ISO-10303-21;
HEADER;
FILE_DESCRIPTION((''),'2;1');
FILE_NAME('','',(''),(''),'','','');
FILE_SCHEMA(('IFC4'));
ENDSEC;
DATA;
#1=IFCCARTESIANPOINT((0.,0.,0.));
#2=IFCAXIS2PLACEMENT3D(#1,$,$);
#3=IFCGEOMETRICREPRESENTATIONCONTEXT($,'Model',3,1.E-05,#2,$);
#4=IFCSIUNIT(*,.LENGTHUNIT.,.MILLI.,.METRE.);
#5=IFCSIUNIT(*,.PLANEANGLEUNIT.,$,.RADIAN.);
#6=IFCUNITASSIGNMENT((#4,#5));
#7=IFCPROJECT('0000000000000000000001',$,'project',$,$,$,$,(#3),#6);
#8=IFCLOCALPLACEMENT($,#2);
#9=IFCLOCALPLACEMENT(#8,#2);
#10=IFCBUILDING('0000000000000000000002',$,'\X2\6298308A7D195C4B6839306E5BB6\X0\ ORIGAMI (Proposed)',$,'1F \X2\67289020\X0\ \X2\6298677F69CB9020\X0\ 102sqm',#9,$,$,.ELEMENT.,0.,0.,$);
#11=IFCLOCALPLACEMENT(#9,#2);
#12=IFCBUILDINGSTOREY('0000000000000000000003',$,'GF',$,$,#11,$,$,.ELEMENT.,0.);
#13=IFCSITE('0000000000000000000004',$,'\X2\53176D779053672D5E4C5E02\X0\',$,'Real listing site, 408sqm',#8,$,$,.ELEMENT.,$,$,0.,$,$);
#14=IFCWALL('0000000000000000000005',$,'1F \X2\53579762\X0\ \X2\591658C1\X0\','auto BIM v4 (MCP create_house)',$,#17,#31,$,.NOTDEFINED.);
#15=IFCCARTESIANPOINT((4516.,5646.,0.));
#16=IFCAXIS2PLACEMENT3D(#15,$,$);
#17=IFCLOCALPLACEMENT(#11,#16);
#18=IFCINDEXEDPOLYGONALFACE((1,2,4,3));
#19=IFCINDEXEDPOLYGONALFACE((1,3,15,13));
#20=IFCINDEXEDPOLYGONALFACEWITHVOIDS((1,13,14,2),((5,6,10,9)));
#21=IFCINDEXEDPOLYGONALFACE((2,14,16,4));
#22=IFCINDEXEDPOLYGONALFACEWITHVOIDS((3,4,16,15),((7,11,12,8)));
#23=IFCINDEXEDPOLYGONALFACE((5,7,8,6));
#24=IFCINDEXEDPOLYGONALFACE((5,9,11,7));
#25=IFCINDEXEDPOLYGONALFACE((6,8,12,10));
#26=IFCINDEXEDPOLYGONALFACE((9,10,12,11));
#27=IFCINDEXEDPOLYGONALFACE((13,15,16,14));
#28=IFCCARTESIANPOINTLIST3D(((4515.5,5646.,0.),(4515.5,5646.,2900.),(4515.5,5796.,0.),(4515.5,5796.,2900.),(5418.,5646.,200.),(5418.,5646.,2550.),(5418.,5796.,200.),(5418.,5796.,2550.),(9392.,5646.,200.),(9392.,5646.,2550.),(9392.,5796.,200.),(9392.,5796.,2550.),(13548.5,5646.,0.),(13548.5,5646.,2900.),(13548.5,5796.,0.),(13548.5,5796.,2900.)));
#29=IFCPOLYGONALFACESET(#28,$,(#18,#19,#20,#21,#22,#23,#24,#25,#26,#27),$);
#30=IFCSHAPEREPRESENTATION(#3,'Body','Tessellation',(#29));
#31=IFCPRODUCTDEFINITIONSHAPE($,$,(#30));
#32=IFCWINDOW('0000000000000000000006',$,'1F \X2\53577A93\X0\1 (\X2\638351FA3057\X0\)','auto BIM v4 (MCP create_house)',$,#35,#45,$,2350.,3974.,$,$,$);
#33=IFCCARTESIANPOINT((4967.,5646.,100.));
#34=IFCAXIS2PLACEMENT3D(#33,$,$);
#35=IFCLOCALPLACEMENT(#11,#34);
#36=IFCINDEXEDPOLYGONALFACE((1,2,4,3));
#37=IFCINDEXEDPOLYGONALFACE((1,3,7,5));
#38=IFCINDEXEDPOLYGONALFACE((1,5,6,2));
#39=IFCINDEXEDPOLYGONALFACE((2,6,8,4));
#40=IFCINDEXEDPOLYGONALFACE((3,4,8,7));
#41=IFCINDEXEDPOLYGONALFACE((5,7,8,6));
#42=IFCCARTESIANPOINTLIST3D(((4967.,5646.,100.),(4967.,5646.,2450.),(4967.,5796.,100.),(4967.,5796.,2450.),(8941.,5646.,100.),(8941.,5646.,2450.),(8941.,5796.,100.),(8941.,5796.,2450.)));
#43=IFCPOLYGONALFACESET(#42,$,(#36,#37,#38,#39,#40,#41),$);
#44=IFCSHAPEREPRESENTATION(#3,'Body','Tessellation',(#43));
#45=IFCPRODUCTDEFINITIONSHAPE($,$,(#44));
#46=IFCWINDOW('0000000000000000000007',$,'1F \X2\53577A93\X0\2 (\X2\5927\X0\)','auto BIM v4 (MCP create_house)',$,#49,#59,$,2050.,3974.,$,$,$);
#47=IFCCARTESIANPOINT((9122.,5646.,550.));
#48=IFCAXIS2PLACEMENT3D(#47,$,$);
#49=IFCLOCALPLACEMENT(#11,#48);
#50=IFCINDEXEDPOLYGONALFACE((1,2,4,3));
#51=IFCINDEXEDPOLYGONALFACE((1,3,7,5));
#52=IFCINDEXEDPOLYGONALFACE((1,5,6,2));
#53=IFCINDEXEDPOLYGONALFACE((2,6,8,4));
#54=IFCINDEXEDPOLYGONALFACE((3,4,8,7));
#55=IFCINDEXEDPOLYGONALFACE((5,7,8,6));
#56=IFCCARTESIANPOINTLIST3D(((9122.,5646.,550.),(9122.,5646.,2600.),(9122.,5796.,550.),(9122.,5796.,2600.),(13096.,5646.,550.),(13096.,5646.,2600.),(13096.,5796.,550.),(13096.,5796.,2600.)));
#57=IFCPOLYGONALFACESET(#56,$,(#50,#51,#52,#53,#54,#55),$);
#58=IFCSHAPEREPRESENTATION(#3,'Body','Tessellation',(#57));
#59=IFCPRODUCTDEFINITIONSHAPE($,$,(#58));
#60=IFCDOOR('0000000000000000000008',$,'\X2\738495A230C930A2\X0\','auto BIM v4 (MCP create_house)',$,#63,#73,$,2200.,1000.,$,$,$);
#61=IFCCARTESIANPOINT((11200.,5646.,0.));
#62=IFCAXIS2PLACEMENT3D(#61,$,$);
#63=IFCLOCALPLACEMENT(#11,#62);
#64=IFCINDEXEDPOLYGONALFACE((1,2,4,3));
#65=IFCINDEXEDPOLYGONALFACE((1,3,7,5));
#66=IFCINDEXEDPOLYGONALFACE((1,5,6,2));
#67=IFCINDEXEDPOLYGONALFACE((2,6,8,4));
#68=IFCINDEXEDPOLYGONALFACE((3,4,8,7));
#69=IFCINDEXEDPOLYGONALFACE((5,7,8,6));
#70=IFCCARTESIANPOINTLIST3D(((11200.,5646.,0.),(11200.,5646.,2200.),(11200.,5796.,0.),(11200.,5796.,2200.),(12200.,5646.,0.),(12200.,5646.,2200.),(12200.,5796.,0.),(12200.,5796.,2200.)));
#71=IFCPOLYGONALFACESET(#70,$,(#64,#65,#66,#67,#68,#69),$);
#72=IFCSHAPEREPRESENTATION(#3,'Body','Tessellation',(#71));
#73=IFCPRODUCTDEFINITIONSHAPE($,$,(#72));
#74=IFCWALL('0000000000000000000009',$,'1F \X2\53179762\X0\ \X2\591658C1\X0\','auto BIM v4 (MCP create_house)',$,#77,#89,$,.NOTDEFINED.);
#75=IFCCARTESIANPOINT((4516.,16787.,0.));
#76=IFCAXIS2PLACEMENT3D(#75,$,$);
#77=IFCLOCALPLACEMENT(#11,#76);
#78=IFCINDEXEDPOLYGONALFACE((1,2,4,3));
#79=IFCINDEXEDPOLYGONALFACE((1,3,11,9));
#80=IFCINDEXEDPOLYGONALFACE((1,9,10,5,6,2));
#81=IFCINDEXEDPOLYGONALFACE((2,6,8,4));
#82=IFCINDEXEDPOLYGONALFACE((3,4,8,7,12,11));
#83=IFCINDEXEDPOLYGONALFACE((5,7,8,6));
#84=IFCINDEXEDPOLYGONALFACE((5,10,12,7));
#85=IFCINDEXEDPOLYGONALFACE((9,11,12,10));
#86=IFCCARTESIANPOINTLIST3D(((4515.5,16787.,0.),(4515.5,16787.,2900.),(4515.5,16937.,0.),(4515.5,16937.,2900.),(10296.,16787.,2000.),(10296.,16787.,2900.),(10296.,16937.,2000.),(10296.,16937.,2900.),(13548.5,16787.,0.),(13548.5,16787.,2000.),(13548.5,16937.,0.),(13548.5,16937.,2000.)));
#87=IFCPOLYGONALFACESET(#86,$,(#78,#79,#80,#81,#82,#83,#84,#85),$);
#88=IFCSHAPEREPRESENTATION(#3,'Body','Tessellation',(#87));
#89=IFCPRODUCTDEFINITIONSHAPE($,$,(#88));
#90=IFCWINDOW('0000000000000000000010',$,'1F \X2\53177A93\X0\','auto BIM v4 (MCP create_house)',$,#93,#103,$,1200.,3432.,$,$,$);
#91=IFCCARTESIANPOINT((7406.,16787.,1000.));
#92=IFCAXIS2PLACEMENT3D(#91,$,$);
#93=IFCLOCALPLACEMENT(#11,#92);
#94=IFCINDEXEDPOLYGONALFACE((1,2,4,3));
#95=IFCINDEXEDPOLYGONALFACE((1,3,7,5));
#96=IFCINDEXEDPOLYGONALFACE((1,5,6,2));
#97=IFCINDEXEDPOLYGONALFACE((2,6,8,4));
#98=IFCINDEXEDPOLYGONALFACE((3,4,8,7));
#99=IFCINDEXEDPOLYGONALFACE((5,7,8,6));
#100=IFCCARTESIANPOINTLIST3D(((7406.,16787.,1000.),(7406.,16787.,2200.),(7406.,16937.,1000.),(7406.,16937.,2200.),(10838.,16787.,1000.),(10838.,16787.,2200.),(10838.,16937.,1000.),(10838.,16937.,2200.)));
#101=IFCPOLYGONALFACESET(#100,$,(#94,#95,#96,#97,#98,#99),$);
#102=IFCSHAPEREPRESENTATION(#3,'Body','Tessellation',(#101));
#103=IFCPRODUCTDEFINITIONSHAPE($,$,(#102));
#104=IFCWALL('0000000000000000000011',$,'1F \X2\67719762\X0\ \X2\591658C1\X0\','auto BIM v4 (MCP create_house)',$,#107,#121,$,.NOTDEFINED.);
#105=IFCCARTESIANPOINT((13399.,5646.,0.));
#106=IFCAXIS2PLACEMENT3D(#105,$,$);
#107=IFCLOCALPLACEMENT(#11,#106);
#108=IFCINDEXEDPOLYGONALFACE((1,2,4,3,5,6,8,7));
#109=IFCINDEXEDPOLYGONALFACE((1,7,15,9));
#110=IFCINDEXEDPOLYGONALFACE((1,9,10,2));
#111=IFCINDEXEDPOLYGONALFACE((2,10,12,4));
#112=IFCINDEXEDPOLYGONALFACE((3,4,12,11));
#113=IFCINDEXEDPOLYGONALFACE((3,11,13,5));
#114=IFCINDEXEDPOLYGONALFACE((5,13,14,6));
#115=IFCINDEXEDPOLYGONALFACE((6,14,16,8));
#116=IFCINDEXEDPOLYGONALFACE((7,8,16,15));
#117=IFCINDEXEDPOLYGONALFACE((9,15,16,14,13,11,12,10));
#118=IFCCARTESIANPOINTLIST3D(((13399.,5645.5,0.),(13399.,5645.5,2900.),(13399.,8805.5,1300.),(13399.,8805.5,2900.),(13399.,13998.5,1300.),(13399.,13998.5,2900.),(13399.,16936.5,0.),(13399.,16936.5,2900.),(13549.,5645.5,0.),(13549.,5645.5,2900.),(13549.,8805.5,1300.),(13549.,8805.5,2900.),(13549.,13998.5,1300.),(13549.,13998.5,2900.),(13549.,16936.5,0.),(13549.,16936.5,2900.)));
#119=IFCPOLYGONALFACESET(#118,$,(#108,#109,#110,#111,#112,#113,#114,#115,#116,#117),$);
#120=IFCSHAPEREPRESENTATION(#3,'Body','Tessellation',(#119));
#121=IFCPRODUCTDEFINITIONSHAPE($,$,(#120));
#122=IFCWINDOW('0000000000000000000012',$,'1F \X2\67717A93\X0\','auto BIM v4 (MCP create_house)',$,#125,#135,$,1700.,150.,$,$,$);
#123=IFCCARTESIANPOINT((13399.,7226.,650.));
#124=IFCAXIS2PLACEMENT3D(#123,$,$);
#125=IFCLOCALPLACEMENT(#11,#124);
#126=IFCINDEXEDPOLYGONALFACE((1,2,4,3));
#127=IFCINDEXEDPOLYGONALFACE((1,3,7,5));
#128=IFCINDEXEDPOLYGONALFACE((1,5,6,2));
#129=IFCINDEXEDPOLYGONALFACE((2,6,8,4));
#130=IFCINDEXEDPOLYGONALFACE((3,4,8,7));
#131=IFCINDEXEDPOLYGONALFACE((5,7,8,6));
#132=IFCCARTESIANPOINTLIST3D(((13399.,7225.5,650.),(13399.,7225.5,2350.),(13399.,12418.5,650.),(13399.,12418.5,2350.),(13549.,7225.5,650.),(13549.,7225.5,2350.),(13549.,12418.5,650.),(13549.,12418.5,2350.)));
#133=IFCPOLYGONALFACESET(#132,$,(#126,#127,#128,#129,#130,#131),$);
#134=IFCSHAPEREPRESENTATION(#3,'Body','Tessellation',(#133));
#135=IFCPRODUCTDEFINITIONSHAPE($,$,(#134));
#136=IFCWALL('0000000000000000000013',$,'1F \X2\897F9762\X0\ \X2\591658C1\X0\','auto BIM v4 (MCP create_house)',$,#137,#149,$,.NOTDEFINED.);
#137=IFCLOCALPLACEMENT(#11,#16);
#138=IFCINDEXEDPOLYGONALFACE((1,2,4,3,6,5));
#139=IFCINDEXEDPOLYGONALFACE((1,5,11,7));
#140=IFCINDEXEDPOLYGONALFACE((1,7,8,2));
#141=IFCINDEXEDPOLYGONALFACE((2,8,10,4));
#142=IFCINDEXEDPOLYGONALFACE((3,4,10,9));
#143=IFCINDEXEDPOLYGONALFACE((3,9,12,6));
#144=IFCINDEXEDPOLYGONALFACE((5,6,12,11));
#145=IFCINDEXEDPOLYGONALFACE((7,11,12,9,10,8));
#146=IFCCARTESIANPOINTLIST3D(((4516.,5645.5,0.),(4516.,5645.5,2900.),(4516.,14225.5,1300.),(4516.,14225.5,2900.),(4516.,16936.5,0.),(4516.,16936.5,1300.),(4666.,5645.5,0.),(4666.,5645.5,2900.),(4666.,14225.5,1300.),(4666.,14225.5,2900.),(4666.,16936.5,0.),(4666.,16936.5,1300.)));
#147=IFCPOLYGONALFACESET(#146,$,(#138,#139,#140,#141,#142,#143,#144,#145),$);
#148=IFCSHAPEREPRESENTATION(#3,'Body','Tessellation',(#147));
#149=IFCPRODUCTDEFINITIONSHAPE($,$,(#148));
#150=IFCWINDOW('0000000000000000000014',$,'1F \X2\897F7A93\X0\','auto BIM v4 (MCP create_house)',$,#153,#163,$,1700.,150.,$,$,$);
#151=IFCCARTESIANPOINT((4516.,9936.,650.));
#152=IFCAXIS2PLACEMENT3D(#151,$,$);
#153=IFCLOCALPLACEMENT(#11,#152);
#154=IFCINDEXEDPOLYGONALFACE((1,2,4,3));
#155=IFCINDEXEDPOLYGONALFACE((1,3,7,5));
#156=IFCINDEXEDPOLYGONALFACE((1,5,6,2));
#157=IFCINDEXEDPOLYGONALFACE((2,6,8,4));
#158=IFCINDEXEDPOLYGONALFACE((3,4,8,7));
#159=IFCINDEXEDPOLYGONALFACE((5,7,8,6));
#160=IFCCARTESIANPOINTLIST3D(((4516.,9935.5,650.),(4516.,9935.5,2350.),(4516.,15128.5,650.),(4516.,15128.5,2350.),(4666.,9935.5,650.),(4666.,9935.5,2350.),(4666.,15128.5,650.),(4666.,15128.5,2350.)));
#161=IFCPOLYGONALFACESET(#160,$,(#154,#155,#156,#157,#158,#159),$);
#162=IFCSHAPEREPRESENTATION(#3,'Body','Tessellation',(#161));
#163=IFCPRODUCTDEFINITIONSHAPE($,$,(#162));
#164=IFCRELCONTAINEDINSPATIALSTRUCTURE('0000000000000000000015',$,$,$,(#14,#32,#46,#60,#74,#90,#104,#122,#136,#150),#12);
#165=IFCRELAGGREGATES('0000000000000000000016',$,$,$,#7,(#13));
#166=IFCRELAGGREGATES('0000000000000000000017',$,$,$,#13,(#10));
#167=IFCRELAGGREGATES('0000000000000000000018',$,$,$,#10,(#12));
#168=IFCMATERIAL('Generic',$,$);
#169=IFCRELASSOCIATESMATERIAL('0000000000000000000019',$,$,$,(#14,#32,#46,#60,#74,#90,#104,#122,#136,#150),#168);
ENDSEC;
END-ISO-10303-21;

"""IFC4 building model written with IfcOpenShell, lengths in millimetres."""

from ifc_helpers import new_model, si_unit, frame, frame_2d, origin, place, context, project, spatial, rectangle, extrude, material, element, fill, save


model = new_model("IFC4")

# Units and contexts
model_context = context("Model", 3, precision=1e-05, world=origin())
ifc_project = project(units=[si_unit("LENGTHUNIT", "METRE", prefix="MILLI"), si_unit("PLANEANGLEUNIT", "RADIAN")], contexts=[model_context])

# Site, building, storey
site_placement = place(None, origin())
site = spatial("IfcSite", under=ifc_project, at=site_placement, Name="北海道札幌市", ObjectType="Real listing site, 408sqm", CompositionType="ELEMENT", RefElevation=0.0)
building_placement = place(site_placement, origin())
building = spatial("IfcBuilding", under=site, at=building_placement, Name="折り紙屋根の家 ORIGAMI (Proposed)", ObjectType="1F 木造 折板構造 102sqm", CompositionType="ELEMENT", ElevationOfRefHeight=0.0, ElevationOfTerrain=0.0)
storey_placement = place(building_placement, origin())
storey = spatial("IfcBuildingStorey", under=building, at=storey_placement, Name="GF", CompositionType="ELEMENT", Elevation=0.0)

# Shared definitions
ifc_material = material(Name="Generic")

# Wall, openings, windows, door
wall_1_placement = place(storey_placement, frame((4516.0, 5646.0, 0.0)))
wall_1 = element("IfcWall", 1, at=wall_1_placement, inside=storey, material=ifc_material, Name="1F 南面 外壁", Description="auto BIM v4 (MCP create_house)", PredefinedType="NOTDEFINED", context=model_context, shape_type="SweptSolid", body=[
    extrude(rectangle(XDim=9033.0, YDim=150.0, at=frame_2d((4516.0, 75.0))), frame((4516.0, 5646.0, 0.0)), (0.0, 0.0, 1.0), 2900.0),
])
opening_1_placement = place(storey_placement, frame((4967.0, 5646.0, 100.0)))
opening_1 = element("IfcOpeningElement", 2, at=opening_1_placement, cuts=wall_1, PredefinedType="NOTDEFINED", context=model_context, shape_type="SweptSolid", body=[
    extrude(rectangle(XDim=3974.0, YDim=150.0, at=frame_2d((1987.0, 75.0))), frame((4967.0, 5646.0, 100.0)), (0.0, 0.0, 1.0), 2350.0),
])
opening_2_placement = place(storey_placement, frame((9122.0, 5646.0, 550.0)))
opening_2 = element("IfcOpeningElement", 3, at=opening_2_placement, cuts=wall_1, PredefinedType="NOTDEFINED", context=model_context, shape_type="SweptSolid", body=[
    extrude(rectangle(XDim=3974.0, YDim=150.0, at=frame_2d((1987.0, 75.0))), frame((9122.0, 5646.0, 550.0)), (0.0, 0.0, 1.0), 2050.0),
])
opening_3_placement = place(storey_placement, frame((11200.0, 5646.0, 0.0)))
opening_3 = element("IfcOpeningElement", 4, at=opening_3_placement, cuts=wall_1, PredefinedType="NOTDEFINED", context=model_context, shape_type="SweptSolid", body=[
    extrude(rectangle(XDim=1000.0, YDim=150.0, at=frame_2d((500.0, 75.0))), frame((11200.0, 5646.0, 0.0)), (0.0, 0.0, 1.0), 2200.0),
])
window_1_placement = place(storey_placement, frame((4967.0, 5646.0, 100.0)))
window_1 = element("IfcWindow", 5, at=window_1_placement, inside=storey, material=ifc_material, Name="1F 南窓1 (掃出し)", Description="auto BIM v4 (MCP create_house)", OverallHeight=2350.0, OverallWidth=3974.0, context=model_context, shape_type="SweptSolid", body=[
    extrude(rectangle(XDim=3974.0, YDim=150.0, at=frame_2d((1987.0, 75.0))), frame((4967.0, 5646.0, 100.0)), (0.0, 0.0, 1.0), 2350.0),
])
fill(opening_1, window_1)
window_2_placement = place(storey_placement, frame((9122.0, 5646.0, 550.0)))
window_2 = element("IfcWindow", 6, at=window_2_placement, inside=storey, material=ifc_material, Name="1F 南窓2 (大)", Description="auto BIM v4 (MCP create_house)", OverallHeight=2050.0, OverallWidth=3974.0, context=model_context, shape_type="SweptSolid", body=[
    extrude(rectangle(XDim=3974.0, YDim=150.0, at=frame_2d((1987.0, 75.0))), frame((9122.0, 5646.0, 550.0)), (0.0, 0.0, 1.0), 2050.0),
])
fill(opening_2, window_2)
door_placement = place(storey_placement, frame((11200.0, 5646.0, 0.0)))
door = element("IfcDoor", 7, at=door_placement, inside=storey, material=ifc_material, Name="玄関ドア", Description="auto BIM v4 (MCP create_house)", OverallHeight=2200.0, OverallWidth=1000.0, context=model_context, shape_type="SweptSolid", body=[
    extrude(rectangle(XDim=1000.0, YDim=150.0, at=frame_2d((500.0, 75.0))), frame((11200.0, 5646.0, 0.0)), (0.0, 0.0, 1.0), 2200.0),
])
fill(opening_3, door)

# Walls, openings, windows
wall_2_placement = place(storey_placement, frame((4516.0, 16787.0, 0.0)))
wall_2 = element("IfcWall", 8, at=wall_2_placement, inside=storey, material=ifc_material, Name="1F 北面 外壁", Description="auto BIM v4 (MCP create_house)", PredefinedType="NOTDEFINED", context=model_context, shape_type="SweptSolid", body=[
    extrude(rectangle(XDim=9033.0, YDim=150.0, at=frame_2d((4516.0, 75.0))), frame((4516.0, 16787.0, 0.0)), (0.0, 0.0, 1.0), 2900.0),
])
opening_4_placement = place(storey_placement, frame((7406.0, 16787.0, 1000.0)))
opening_4 = element("IfcOpeningElement", 9, at=opening_4_placement, cuts=wall_2, PredefinedType="NOTDEFINED", context=model_context, shape_type="SweptSolid", body=[
    extrude(rectangle(XDim=3432.0, YDim=150.0, at=frame_2d((1716.0, 75.0))), frame((7406.0, 16787.0, 1000.0)), (0.0, 0.0, 1.0), 1200.0),
])
window_3_placement = place(storey_placement, frame((7406.0, 16787.0, 1000.0)))
window_3 = element("IfcWindow", 10, at=window_3_placement, inside=storey, material=ifc_material, Name="1F 北窓", Description="auto BIM v4 (MCP create_house)", OverallHeight=1200.0, OverallWidth=3432.0, context=model_context, shape_type="SweptSolid", body=[
    extrude(rectangle(XDim=3432.0, YDim=150.0, at=frame_2d((1716.0, 75.0))), frame((7406.0, 16787.0, 1000.0)), (0.0, 0.0, 1.0), 1200.0),
])
fill(opening_4, window_3)
wall_3_placement = place(storey_placement, frame((13399.0, 5646.0, 0.0)))
wall_3 = element("IfcWall", 11, at=wall_3_placement, inside=storey, material=ifc_material, Name="1F 東面 外壁", Description="auto BIM v4 (MCP create_house)", PredefinedType="NOTDEFINED", context=model_context, shape_type="SweptSolid", body=[
    extrude(rectangle(XDim=150.0, YDim=11291.0, at=frame_2d((75.0, 5645.0))), frame((13399.0, 5646.0, 0.0)), (0.0, 0.0, 1.0), 2900.0),
])
opening_5_placement = place(storey_placement, frame((13399.0, 7226.0, 650.0)))
opening_5 = element("IfcOpeningElement", 12, at=opening_5_placement, cuts=wall_3, PredefinedType="NOTDEFINED", context=model_context, shape_type="SweptSolid", body=[
    extrude(rectangle(XDim=150.0, YDim=5193.0, at=frame_2d((75.0, 2596.0))), frame((13399.0, 7226.0, 650.0)), (0.0, 0.0, 1.0), 1700.0),
])
window_4_placement = place(storey_placement, frame((13399.0, 7226.0, 650.0)))
window_4 = element("IfcWindow", 13, at=window_4_placement, inside=storey, material=ifc_material, Name="1F 東窓", Description="auto BIM v4 (MCP create_house)", OverallHeight=1700.0, OverallWidth=150.0, context=model_context, shape_type="SweptSolid", body=[
    extrude(rectangle(XDim=150.0, YDim=5193.0, at=frame_2d((75.0, 2596.0))), frame((13399.0, 7226.0, 650.0)), (0.0, 0.0, 1.0), 1700.0),
])
fill(opening_5, window_4)
wall_4_placement = place(storey_placement, frame((4516.0, 5646.0, 0.0)))
wall_4 = element("IfcWall", 14, at=wall_4_placement, inside=storey, material=ifc_material, Name="1F 西面 外壁", Description="auto BIM v4 (MCP create_house)", PredefinedType="NOTDEFINED", context=model_context, shape_type="SweptSolid", body=[
    extrude(rectangle(XDim=150.0, YDim=11291.0, at=frame_2d((75.0, 5645.0))), frame((4516.0, 5646.0, 0.0)), (0.0, 0.0, 1.0), 2900.0),
])
opening_6_placement = place(storey_placement, frame((4516.0, 9936.0, 650.0)))
opening_6 = element("IfcOpeningElement", 15, at=opening_6_placement, cuts=wall_4, PredefinedType="NOTDEFINED", context=model_context, shape_type="SweptSolid", body=[
    extrude(rectangle(XDim=150.0, YDim=5193.0, at=frame_2d((75.0, 2596.0))), frame((4516.0, 9936.0, 650.0)), (0.0, 0.0, 1.0), 1700.0),
])
window_5_placement = place(storey_placement, frame((4516.0, 9936.0, 650.0)))
window_5 = element("IfcWindow", 16, at=window_5_placement, inside=storey, material=ifc_material, Name="1F 西窓", Description="auto BIM v4 (MCP create_house)", OverallHeight=1700.0, OverallWidth=150.0, context=model_context, shape_type="SweptSolid", body=[
    extrude(rectangle(XDim=150.0, YDim=5193.0, at=frame_2d((75.0, 2596.0))), frame((4516.0, 9936.0, 650.0)), (0.0, 0.0, 1.0), 1700.0),
])
fill(opening_6, window_5)

save(model, "model.ifc")
